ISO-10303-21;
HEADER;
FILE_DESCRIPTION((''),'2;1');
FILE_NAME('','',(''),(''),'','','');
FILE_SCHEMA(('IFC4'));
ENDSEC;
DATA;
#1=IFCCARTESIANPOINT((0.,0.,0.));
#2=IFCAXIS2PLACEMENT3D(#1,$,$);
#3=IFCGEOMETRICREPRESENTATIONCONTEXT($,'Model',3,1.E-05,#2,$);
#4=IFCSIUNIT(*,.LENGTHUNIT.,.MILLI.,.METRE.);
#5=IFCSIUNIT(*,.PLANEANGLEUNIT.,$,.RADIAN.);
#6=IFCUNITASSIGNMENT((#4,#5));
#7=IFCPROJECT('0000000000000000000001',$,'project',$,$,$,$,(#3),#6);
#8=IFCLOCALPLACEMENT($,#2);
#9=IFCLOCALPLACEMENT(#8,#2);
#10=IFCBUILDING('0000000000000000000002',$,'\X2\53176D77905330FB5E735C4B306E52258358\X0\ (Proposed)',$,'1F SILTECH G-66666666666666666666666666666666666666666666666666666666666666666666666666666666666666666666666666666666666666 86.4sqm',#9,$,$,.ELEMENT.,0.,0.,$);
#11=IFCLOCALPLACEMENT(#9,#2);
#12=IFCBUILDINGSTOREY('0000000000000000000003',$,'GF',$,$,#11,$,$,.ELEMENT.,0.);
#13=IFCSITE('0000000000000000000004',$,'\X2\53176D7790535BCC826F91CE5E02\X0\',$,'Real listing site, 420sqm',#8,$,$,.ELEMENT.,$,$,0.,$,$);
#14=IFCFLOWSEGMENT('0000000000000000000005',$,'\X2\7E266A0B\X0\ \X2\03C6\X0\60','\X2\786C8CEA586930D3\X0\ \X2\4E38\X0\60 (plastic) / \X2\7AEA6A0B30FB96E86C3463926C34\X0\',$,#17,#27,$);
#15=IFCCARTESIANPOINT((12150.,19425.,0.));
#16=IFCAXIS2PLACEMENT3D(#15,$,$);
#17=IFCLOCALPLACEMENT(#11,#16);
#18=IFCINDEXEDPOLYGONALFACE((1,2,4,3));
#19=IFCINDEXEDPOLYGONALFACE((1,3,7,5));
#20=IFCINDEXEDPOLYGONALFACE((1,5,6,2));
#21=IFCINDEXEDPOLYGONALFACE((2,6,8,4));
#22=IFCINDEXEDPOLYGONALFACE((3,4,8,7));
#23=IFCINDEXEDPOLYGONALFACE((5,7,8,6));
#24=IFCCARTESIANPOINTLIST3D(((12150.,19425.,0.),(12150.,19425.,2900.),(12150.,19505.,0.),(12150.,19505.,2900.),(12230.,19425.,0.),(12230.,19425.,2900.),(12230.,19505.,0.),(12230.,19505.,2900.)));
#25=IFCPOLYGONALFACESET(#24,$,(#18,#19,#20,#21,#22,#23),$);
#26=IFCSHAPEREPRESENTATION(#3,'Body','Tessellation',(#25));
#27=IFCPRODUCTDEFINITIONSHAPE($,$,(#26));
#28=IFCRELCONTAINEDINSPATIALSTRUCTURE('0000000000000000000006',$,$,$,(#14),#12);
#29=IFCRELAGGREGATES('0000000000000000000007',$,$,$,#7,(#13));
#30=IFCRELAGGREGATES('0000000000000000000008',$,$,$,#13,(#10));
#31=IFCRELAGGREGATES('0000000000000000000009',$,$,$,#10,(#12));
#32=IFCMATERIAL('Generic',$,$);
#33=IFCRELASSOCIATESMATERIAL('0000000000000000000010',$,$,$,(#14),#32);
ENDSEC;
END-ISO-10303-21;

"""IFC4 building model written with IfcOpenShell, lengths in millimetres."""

from ifc_helpers import new_model, si_unit, frame, frame_2d, origin, place, context, project, spatial, rectangle, extrude, material, element, save


model = new_model("IFC4")

# Units and contexts
model_context = context("Model", 3, precision=1e-05, world=origin())
ifc_project = project(units=[si_unit("LENGTHUNIT", "METRE", prefix="MILLI"), si_unit("PLANEANGLEUNIT", "RADIAN")], contexts=[model_context])

# Site, building, storey
site_placement = place(None, origin())
site = spatial("IfcSite", under=ifc_project, at=site_placement, Name="北海道富良野市", ObjectType="Real listing site, 420sqm", CompositionType="ELEMENT", RefElevation=0.0)
building_placement = place(site_placement, origin())
building = spatial("IfcBuilding", under=site, at=building_placement, Name="北海道・平屋の別荘 (Proposed)", ObjectType="1F SILTECH G-66666666666666666666666666666666666666666666666666666666666666666666666666666666666666666666666666666666666666 86.4sqm", CompositionType="ELEMENT", ElevationOfRefHeight=0.0, ElevationOfTerrain=0.0)
storey_placement = place(building_placement, origin())
storey = spatial("IfcBuildingStorey", under=building, at=storey_placement, Name="GF", CompositionType="ELEMENT", Elevation=0.0)

# Shared definitions
ifc_material_1 = material(Name="Generic")

# Flow segment
flow_segment_placement = place(storey_placement, frame((12150.0, 19425.0, 0.0)))
element("IfcFlowSegment", 1, at=flow_segment_placement, inside=storey, material=ifc_material_1, Name="縦樋 φ60", Description="硬質塩ビ 丸60 (plastic) / 竪樋・雨水排水", context=model_context, shape_type="SweptSolid", body=[
    extrude(rectangle(XDim=80.0, YDim=80.0, at=frame_2d((40.0, 40.0))), frame((12150.0, 19425.0, 0.0)), (0.0, 0.0, 1.0), 2900.0),
])

save(model, "model.ifc")
